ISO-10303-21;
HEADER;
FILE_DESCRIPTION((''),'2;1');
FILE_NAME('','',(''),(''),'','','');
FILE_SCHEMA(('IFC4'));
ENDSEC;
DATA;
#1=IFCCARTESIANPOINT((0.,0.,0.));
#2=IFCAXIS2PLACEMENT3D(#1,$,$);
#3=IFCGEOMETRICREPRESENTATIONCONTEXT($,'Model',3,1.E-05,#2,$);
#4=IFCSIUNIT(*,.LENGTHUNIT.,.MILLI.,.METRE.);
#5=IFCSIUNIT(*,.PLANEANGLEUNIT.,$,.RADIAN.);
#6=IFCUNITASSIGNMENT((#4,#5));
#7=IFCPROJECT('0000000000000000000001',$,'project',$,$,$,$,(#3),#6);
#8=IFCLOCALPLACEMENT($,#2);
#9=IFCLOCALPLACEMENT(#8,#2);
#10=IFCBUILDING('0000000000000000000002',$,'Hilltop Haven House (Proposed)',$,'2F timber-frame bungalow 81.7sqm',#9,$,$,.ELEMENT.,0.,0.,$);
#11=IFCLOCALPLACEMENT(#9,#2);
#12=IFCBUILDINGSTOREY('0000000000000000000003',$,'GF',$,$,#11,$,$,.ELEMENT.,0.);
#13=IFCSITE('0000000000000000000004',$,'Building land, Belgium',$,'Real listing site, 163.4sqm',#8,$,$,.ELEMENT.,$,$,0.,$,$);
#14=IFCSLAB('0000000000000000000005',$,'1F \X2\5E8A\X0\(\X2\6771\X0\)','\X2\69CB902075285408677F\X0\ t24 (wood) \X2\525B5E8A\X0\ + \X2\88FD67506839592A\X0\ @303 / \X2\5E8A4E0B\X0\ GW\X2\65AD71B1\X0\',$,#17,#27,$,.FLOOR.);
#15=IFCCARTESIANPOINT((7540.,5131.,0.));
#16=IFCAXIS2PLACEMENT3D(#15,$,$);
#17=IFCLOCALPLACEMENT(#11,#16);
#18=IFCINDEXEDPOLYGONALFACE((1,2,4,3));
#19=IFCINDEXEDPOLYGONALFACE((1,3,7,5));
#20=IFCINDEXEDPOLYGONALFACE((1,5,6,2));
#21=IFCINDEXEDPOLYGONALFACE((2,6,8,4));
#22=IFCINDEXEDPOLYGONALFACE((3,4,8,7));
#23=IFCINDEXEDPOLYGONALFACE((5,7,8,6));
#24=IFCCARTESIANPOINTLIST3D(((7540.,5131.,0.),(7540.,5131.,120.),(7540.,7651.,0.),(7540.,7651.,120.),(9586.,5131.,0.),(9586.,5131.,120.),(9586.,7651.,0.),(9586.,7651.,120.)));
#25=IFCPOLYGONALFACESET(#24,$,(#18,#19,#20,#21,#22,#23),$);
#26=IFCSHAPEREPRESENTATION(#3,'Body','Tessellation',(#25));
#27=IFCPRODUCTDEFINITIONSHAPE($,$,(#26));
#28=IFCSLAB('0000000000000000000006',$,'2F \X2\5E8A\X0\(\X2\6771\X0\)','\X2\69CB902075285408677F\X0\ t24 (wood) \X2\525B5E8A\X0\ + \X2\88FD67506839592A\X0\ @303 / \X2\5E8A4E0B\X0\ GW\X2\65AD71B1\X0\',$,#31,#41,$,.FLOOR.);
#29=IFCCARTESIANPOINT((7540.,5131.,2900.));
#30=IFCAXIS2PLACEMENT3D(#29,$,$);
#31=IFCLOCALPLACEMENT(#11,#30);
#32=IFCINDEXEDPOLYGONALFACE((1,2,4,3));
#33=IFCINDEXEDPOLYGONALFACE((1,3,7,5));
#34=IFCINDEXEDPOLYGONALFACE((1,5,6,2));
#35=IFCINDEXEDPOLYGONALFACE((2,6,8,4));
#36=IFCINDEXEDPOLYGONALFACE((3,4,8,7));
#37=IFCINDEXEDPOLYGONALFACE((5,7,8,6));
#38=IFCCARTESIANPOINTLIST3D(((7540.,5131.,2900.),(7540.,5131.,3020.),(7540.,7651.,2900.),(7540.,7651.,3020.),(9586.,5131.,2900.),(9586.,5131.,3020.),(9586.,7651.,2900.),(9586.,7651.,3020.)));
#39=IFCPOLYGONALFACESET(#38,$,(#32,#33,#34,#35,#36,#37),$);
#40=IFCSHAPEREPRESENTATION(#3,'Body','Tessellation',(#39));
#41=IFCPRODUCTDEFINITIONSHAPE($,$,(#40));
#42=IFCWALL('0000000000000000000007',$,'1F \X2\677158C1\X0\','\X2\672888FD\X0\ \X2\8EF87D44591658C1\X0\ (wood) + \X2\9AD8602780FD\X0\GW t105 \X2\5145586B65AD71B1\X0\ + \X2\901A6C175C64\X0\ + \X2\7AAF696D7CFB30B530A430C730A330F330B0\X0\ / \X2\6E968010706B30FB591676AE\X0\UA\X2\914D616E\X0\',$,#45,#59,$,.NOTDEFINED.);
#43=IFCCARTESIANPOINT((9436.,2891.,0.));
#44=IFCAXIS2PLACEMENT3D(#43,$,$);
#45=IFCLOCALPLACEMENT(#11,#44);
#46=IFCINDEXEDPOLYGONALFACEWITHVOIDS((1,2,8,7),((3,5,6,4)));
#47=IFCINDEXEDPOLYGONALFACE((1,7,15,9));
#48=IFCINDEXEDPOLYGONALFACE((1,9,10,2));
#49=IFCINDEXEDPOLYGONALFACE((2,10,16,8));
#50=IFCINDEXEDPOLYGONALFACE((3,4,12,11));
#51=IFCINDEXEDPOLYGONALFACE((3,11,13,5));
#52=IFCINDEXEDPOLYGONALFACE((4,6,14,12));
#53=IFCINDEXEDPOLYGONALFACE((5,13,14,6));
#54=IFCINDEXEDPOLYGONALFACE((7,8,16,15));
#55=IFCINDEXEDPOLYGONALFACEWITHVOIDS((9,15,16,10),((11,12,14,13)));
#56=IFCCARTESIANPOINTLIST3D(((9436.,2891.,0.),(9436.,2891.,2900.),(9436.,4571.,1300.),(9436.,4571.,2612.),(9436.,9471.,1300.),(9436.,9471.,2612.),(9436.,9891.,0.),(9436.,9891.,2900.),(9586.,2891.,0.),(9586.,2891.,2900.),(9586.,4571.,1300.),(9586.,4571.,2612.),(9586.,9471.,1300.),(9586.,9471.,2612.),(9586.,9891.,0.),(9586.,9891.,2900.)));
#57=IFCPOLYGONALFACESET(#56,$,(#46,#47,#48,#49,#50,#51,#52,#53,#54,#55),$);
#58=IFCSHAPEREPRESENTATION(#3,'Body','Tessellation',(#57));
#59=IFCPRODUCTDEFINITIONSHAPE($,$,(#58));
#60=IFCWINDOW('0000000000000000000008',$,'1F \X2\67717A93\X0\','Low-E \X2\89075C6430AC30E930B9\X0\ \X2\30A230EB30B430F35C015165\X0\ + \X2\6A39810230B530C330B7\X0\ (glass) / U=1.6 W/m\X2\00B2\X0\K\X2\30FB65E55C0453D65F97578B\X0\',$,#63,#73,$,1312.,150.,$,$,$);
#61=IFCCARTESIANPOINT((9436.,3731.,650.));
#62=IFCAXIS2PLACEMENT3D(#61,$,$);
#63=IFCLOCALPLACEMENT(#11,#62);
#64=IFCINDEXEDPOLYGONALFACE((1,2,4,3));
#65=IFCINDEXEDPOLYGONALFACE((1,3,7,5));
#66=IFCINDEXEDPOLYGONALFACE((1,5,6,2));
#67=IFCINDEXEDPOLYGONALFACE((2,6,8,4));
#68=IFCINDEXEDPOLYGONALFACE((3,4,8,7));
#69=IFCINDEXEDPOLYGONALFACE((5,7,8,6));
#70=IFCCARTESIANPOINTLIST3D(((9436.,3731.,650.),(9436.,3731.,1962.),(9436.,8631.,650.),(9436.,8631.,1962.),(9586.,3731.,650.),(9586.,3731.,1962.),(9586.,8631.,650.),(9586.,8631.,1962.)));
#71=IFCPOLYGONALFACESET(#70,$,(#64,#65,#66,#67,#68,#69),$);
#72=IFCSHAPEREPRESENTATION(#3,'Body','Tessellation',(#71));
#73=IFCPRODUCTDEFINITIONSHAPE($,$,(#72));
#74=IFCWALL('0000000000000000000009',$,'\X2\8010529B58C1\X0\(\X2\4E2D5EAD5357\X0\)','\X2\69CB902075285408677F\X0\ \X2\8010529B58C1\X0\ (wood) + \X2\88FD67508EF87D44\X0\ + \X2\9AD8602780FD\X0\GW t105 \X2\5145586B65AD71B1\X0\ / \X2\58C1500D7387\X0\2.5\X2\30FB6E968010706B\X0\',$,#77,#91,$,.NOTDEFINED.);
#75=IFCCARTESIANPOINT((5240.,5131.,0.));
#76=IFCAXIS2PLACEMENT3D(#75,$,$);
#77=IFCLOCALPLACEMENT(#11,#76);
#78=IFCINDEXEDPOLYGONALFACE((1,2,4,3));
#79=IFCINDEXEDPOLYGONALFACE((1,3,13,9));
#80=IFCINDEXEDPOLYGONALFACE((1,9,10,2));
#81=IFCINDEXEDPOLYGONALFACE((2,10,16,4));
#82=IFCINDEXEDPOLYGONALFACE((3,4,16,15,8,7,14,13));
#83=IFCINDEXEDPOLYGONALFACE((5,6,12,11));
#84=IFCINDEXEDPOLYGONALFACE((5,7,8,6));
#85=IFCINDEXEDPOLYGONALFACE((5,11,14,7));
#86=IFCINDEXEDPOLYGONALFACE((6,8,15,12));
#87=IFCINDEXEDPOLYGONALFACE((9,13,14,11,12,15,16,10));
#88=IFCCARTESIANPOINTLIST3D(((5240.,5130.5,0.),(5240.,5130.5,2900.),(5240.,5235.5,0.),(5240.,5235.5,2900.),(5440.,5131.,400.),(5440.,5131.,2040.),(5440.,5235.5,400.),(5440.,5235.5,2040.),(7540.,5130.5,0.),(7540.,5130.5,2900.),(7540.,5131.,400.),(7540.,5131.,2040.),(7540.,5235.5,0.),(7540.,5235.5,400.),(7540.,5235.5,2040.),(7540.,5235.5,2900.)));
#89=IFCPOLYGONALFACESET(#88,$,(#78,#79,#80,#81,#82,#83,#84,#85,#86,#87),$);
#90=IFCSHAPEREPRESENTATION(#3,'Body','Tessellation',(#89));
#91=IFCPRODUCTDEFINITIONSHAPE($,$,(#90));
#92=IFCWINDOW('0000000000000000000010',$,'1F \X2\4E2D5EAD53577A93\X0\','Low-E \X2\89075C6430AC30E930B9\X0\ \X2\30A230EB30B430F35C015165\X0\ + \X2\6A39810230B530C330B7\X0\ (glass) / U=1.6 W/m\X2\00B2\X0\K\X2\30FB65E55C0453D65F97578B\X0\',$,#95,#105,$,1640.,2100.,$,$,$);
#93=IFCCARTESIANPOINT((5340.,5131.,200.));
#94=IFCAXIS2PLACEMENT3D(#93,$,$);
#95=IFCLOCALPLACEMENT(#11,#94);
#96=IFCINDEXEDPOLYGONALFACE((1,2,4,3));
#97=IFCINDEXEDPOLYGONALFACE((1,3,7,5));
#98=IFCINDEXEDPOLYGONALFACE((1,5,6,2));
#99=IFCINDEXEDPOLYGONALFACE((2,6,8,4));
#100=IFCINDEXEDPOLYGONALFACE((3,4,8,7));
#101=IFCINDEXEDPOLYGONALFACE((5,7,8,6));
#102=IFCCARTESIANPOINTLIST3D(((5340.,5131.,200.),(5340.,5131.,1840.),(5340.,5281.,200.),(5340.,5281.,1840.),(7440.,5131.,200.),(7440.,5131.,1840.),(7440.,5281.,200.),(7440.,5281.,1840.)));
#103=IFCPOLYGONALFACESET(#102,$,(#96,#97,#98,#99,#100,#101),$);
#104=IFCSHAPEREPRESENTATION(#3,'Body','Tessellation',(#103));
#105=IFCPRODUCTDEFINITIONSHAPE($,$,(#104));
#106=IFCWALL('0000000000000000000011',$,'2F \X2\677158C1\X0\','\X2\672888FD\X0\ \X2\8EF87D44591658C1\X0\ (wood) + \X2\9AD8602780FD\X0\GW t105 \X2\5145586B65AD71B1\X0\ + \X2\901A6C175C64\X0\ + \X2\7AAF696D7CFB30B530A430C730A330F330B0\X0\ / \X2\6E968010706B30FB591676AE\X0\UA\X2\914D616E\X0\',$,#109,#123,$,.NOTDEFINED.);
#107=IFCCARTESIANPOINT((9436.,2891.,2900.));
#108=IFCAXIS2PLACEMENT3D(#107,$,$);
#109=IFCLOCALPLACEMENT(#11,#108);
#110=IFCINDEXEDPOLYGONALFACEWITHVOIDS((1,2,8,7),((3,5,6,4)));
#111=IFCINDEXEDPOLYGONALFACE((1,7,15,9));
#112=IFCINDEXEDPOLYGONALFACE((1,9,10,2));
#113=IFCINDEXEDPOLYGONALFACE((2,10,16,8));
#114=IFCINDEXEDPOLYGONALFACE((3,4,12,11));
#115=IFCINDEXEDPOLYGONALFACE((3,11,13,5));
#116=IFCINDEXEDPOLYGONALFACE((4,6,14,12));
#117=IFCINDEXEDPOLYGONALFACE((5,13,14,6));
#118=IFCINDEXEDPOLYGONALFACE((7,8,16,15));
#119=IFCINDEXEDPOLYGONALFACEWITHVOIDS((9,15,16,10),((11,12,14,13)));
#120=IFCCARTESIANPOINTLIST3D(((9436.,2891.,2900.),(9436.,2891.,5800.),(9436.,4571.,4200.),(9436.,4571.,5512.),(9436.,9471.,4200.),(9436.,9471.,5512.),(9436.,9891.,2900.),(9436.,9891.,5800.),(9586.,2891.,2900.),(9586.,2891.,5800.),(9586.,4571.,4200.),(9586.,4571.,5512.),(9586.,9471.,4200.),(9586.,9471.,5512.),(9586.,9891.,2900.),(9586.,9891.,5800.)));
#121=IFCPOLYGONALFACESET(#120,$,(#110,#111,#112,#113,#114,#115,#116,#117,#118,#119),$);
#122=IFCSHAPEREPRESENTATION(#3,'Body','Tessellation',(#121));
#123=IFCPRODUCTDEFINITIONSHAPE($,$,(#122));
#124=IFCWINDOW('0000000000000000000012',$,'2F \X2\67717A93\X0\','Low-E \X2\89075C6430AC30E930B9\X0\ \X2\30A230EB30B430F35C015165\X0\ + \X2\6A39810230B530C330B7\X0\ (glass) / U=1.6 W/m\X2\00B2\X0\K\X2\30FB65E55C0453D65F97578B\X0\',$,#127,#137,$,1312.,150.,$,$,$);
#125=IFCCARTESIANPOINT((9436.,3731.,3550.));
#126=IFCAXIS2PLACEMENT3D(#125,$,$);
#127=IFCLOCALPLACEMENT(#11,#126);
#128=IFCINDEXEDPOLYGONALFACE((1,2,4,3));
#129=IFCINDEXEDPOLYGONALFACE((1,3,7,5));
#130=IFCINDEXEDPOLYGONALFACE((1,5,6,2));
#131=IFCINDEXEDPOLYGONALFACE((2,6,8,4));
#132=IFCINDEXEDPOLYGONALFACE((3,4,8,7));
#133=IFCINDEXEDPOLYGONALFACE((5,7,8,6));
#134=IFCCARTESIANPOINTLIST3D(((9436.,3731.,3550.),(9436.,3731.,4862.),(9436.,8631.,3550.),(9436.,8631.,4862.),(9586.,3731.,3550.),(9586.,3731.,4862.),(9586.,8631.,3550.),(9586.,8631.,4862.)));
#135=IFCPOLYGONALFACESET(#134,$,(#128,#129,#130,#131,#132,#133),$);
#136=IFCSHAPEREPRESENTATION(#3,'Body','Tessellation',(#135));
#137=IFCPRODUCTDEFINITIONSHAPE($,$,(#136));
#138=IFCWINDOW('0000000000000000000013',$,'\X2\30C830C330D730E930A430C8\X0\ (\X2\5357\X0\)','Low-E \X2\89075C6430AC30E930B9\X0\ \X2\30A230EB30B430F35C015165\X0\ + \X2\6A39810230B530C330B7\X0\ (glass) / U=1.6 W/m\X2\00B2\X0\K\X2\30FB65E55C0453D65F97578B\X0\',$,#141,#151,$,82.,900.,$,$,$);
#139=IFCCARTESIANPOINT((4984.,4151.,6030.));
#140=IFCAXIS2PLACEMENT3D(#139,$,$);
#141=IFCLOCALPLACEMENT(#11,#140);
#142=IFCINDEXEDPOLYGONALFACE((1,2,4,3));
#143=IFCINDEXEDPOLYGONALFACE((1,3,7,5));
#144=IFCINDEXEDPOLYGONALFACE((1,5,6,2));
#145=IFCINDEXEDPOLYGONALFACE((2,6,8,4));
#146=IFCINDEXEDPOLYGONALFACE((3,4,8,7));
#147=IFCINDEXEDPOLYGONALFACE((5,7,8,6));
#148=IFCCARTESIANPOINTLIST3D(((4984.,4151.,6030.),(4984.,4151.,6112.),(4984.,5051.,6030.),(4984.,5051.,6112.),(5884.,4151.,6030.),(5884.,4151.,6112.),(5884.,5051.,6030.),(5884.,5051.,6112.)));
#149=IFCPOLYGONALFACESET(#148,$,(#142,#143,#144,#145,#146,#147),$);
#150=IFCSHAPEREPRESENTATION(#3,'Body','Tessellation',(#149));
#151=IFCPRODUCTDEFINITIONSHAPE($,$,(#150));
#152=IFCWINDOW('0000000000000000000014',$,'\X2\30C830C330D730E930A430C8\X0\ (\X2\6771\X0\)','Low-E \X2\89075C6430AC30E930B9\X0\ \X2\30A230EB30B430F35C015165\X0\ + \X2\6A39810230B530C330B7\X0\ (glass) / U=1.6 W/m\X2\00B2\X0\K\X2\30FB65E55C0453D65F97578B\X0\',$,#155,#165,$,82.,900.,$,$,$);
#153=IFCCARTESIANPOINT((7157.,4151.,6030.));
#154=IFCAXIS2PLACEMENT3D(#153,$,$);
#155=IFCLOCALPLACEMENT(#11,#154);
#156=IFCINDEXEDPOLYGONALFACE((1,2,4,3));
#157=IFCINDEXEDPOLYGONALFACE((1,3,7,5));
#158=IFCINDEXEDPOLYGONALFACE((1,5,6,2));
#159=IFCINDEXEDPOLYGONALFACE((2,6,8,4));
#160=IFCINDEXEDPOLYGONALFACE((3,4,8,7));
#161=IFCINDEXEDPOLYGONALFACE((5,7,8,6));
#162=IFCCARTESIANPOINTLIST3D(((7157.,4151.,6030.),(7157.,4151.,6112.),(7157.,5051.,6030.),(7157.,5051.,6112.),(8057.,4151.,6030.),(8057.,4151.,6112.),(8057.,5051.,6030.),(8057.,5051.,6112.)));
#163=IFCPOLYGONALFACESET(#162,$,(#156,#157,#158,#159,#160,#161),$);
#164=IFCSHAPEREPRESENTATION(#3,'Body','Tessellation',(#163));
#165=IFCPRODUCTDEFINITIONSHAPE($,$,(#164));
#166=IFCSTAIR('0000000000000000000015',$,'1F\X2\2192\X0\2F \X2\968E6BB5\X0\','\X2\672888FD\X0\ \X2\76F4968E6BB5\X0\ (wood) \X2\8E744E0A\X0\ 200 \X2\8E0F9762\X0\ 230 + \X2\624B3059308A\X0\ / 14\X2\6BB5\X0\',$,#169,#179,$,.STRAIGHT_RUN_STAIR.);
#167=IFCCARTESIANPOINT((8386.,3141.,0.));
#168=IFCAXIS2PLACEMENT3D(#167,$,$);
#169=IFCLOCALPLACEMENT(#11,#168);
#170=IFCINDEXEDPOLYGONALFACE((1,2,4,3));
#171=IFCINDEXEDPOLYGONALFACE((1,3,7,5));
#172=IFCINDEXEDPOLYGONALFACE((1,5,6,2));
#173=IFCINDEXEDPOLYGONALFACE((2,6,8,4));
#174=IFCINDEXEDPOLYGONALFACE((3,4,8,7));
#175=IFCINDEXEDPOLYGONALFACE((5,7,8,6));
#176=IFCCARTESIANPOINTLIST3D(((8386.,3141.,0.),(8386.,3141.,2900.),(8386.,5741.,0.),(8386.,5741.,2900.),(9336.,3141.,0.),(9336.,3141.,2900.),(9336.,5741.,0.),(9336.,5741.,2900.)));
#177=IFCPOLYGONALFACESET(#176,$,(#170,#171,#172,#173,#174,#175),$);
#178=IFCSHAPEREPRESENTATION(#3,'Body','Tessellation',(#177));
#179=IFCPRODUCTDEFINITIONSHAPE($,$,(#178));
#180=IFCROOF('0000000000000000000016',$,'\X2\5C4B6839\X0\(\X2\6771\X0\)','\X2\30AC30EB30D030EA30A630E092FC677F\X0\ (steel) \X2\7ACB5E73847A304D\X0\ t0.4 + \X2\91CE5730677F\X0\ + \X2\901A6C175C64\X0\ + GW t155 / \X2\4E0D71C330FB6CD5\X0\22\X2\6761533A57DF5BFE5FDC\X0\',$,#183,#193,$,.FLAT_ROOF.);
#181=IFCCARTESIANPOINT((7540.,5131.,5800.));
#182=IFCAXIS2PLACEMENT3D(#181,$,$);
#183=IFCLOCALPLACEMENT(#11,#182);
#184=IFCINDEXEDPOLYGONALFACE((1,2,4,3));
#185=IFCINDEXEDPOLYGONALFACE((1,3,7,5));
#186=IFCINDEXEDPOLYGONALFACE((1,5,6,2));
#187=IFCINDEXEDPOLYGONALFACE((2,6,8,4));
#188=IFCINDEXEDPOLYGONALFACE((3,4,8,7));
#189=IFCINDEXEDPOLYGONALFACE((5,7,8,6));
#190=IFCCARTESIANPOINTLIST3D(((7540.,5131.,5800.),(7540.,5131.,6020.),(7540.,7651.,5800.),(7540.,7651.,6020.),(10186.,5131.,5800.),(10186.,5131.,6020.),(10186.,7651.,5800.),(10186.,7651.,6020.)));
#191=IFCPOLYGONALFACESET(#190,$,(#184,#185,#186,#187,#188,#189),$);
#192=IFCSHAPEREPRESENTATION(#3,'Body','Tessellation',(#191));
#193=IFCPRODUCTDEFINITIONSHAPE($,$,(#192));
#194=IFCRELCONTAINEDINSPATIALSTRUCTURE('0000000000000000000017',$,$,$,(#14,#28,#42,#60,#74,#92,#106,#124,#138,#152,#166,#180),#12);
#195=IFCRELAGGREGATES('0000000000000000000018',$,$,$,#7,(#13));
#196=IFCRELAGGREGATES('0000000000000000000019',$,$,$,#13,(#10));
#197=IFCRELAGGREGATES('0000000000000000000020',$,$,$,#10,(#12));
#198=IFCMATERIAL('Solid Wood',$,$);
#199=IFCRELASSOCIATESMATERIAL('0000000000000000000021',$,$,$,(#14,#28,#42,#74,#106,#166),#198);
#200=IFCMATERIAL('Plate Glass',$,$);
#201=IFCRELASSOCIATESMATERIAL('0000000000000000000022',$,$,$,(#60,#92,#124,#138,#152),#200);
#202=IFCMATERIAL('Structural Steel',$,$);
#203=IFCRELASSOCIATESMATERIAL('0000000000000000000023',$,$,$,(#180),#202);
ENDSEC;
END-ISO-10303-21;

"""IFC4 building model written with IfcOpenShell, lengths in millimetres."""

from ifc_helpers import new_model, si_unit, frame, frame_2d, origin, place, context, project, spatial, rectangle, extrude, material, element, fill, save


model = new_model("IFC4")

# Units and contexts
model_context = context("Model", 3, precision=1e-05, world=origin())
ifc_project = project(units=[si_unit("LENGTHUNIT", "METRE", prefix="MILLI"), si_unit("PLANEANGLEUNIT", "RADIAN")], contexts=[model_context])

# Site, building, storey
site_placement = place(None, origin())
site = spatial("IfcSite", under=ifc_project, at=site_placement, Name="Building land, Belgium", ObjectType="Real listing site, 163.4sqm", CompositionType="ELEMENT", RefElevation=0.0)
building_placement = place(site_placement, origin())
building = spatial("IfcBuilding", under=site, at=building_placement, Name="Hilltop Haven House (Proposed)", ObjectType="2F timber-frame bungalow 81.7sqm", CompositionType="ELEMENT", ElevationOfRefHeight=0.0, ElevationOfTerrain=0.0)
storey_placement = place(building_placement, origin())
storey = spatial("IfcBuildingStorey", under=building, at=storey_placement, Name="GF", CompositionType="ELEMENT", Elevation=0.0)

# Slabs
ifc_material_1 = material(Name="Solid Wood")
slab_1_placement = place(storey_placement, frame((7540.0, 5131.0, 0.0)))
element("IfcSlab", 1, at=slab_1_placement, inside=storey, material=ifc_material_1, Name="1F 床(東)", Description="構造用合板 t24 (wood) 剛床 + 製材根太 @303 / 床下 GW断熱", PredefinedType="FLOOR", context=model_context, shape_type="SweptSolid", body=[
    extrude(rectangle(XDim=2046.0, YDim=2520.0, at=frame_2d((1023.0, 1260.0))), frame((7540.0, 5131.0, 0.0)), (0.0, 0.0, 1.0), 120.0),
])
slab_2_placement = place(storey_placement, frame((7540.0, 5131.0, 2900.0)))
element("IfcSlab", 2, at=slab_2_placement, inside=storey, material=ifc_material_1, Name="2F 床(東)", Description="構造用合板 t24 (wood) 剛床 + 製材根太 @303 / 床下 GW断熱", PredefinedType="FLOOR", context=model_context, shape_type="SweptSolid", body=[
    extrude(rectangle(XDim=2046.0, YDim=2520.0, at=frame_2d((1023.0, 1260.0))), frame((7540.0, 5131.0, 2900.0)), (0.0, 0.0, 1.0), 120.0),
])

# Walls, openings, windows
wall_1_placement = place(storey_placement, frame((9436.0, 2891.0, 0.0)))
wall_1 = element("IfcWall", 3, at=wall_1_placement, inside=storey, material=ifc_material_1, Name="1F 東壁", Description="木製 軸組外壁 (wood) + 高性能GW t105 充填断熱 + 通気層 + 窯業系サイディング / 準耐火・外皮UA配慮", PredefinedType="NOTDEFINED", context=model_context, shape_type="SweptSolid", body=[
    extrude(rectangle(XDim=150.0, YDim=7000.0, at=frame_2d((75.0, 3500.0))), frame((9436.0, 2891.0, 0.0)), (0.0, 0.0, 1.0), 2900.0),
])
opening_1_placement = place(storey_placement, frame((9436.0, 3731.0, 650.0)))
opening_1 = element("IfcOpeningElement", 4, at=opening_1_placement, cuts=wall_1, PredefinedType="NOTDEFINED", context=model_context, shape_type="SweptSolid", body=[
    extrude(rectangle(XDim=150.0, YDim=4900.0, at=frame_2d((75.0, 2450.0))), frame((9436.0, 3731.0, 650.0)), (0.0, 0.0, 1.0), 1312.0),
])
ifc_material_2 = material(Name="Plate Glass")
window_1_placement = place(storey_placement, frame((9436.0, 3731.0, 650.0)))
window_1 = element("IfcWindow", 5, at=window_1_placement, inside=storey, material=ifc_material_2, Name="1F 東窓", Description="Low-E 複層ガラス アルゴン封入 + 樹脂サッシ (glass) / U=1.6 W/m²K・日射取得型", OverallHeight=1312.0, OverallWidth=150.0, context=model_context, shape_type="SweptSolid", body=[
    extrude(rectangle(XDim=150.0, YDim=4900.0, at=frame_2d((75.0, 2450.0))), frame((9436.0, 3731.0, 650.0)), (0.0, 0.0, 1.0), 1312.0),
])
fill(opening_1, window_1)
wall_2_placement = place(storey_placement, frame((5240.0, 5131.0, 0.0)))
wall_2 = element("IfcWall", 6, at=wall_2_placement, inside=storey, material=ifc_material_1, Name="耐力壁(中庭南)", Description="構造用合板 耐力壁 (wood) + 製材軸組 + 高性能GW t105 充填断熱 / 壁倍率2.5・準耐火", PredefinedType="NOTDEFINED", context=model_context, shape_type="SweptSolid", body=[
    extrude(rectangle(XDim=2300.0, YDim=105.0, at=frame_2d((1150.0, 52.0))), frame((5240.0, 5131.0, 0.0)), (0.0, 0.0, 1.0), 2900.0),
])
opening_2_placement = place(storey_placement, frame((5340.0, 5131.0, 200.0)))
opening_2 = element("IfcOpeningElement", 7, at=opening_2_placement, cuts=wall_2, PredefinedType="NOTDEFINED", context=model_context, shape_type="SweptSolid", body=[
    extrude(rectangle(XDim=2100.0, YDim=150.0, at=frame_2d((1050.0, 75.0))), frame((5340.0, 5131.0, 200.0)), (0.0, 0.0, 1.0), 1640.0),
])
window_2_placement = place(storey_placement, frame((5340.0, 5131.0, 200.0)))
window_2 = element("IfcWindow", 8, at=window_2_placement, inside=storey, material=ifc_material_2, Name="1F 中庭南窓", Description="Low-E 複層ガラス アルゴン封入 + 樹脂サッシ (glass) / U=1.6 W/m²K・日射取得型", OverallHeight=1640.0, OverallWidth=2100.0, context=model_context, shape_type="SweptSolid", body=[
    extrude(rectangle(XDim=2100.0, YDim=150.0, at=frame_2d((1050.0, 75.0))), frame((5340.0, 5131.0, 200.0)), (0.0, 0.0, 1.0), 1640.0),
])
fill(opening_2, window_2)

# Wall, opening, window
wall_3_placement = place(storey_placement, frame((9436.0, 2891.0, 2900.0)))
wall_3 = element("IfcWall", 9, at=wall_3_placement, inside=storey, material=ifc_material_1, Name="2F 東壁", Description="木製 軸組外壁 (wood) + 高性能GW t105 充填断熱 + 通気層 + 窯業系サイディング / 準耐火・外皮UA配慮", PredefinedType="NOTDEFINED", context=model_context, shape_type="SweptSolid", body=[
    extrude(rectangle(XDim=150.0, YDim=7000.0, at=frame_2d((75.0, 3500.0))), frame((9436.0, 2891.0, 2900.0)), (0.0, 0.0, 1.0), 2900.0),
])
opening_3_placement = place(storey_placement, frame((9436.0, 3731.0, 3550.0)))
opening_3 = element("IfcOpeningElement", 10, at=opening_3_placement, cuts=wall_3, PredefinedType="NOTDEFINED", context=model_context, shape_type="SweptSolid", body=[
    extrude(rectangle(XDim=150.0, YDim=4900.0, at=frame_2d((75.0, 2450.0))), frame((9436.0, 3731.0, 3550.0)), (0.0, 0.0, 1.0), 1312.0),
])
window_3_placement = place(storey_placement, frame((9436.0, 3731.0, 3550.0)))
window_3 = element("IfcWindow", 11, at=window_3_placement, inside=storey, material=ifc_material_2, Name="2F 東窓", Description="Low-E 複層ガラス アルゴン封入 + 樹脂サッシ (glass) / U=1.6 W/m²K・日射取得型", OverallHeight=1312.0, OverallWidth=150.0, context=model_context, shape_type="SweptSolid", body=[
    extrude(rectangle(XDim=150.0, YDim=4900.0, at=frame_2d((75.0, 2450.0))), frame((9436.0, 3731.0, 3550.0)), (0.0, 0.0, 1.0), 1312.0),
])
fill(opening_3, window_3)

# Windows
window_4_placement = place(storey_placement, frame((4984.0, 4151.0, 6030.0)))
element("IfcWindow", 12, at=window_4_placement, inside=storey, material=ifc_material_2, Name="トップライト (南)", Description="Low-E 複層ガラス アルゴン封入 + 樹脂サッシ (glass) / U=1.6 W/m²K・日射取得型", OverallHeight=82.0, OverallWidth=900.0, context=model_context, shape_type="SweptSolid", body=[
    extrude(rectangle(XDim=900.0, YDim=900.0, at=frame_2d((450.0, 450.0))), frame((4984.0, 4151.0, 6030.0)), (0.0, 0.0, 1.0), 82.0),
])
window_5_placement = place(storey_placement, frame((7157.0, 4151.0, 6030.0)))
element("IfcWindow", 13, at=window_5_placement, inside=storey, material=ifc_material_2, Name="トップライト (東)", Description="Low-E 複層ガラス アルゴン封入 + 樹脂サッシ (glass) / U=1.6 W/m²K・日射取得型", OverallHeight=82.0, OverallWidth=900.0, context=model_context, shape_type="SweptSolid", body=[
    extrude(rectangle(XDim=900.0, YDim=900.0, at=frame_2d((450.0, 450.0))), frame((7157.0, 4151.0, 6030.0)), (0.0, 0.0, 1.0), 82.0),
])

# Stair
stair_placement = place(storey_placement, frame((8386.0, 3141.0, 0.0)))
element("IfcStair", 14, at=stair_placement, inside=storey, material=ifc_material_1, Name="1F→2F 階段", Description="木製 直階段 (wood) 蹴上 200 踏面 230 + 手すり / 14段", PredefinedType="STRAIGHT_RUN_STAIR", context=model_context, shape_type="SweptSolid", body=[
    extrude(rectangle(XDim=950.0, YDim=2600.0, at=frame_2d((475.0, 1300.0))), frame((8386.0, 3141.0, 0.0)), (0.0, 0.0, 1.0), 2900.0),
])

# Roof
ifc_material_3 = material(Name="Structural Steel")
roof_placement = place(storey_placement, frame((7540.0, 5131.0, 5800.0)))
element("IfcRoof", 15, at=roof_placement, inside=storey, material=ifc_material_3, Name="屋根(東)", Description="ガルバリウム鋼板 (steel) 立平葺き t0.4 + 野地板 + 通気層 + GW t155 / 不燃・法22条区域対応", PredefinedType="FLAT_ROOF", context=model_context, shape_type="SweptSolid", body=[
    extrude(rectangle(XDim=2646.0, YDim=2520.0, at=frame_2d((1323.0, 1260.0))), frame((7540.0, 5131.0, 5800.0)), (0.0, 0.0, 1.0), 220.0),
])

save(model, "model.ifc")
